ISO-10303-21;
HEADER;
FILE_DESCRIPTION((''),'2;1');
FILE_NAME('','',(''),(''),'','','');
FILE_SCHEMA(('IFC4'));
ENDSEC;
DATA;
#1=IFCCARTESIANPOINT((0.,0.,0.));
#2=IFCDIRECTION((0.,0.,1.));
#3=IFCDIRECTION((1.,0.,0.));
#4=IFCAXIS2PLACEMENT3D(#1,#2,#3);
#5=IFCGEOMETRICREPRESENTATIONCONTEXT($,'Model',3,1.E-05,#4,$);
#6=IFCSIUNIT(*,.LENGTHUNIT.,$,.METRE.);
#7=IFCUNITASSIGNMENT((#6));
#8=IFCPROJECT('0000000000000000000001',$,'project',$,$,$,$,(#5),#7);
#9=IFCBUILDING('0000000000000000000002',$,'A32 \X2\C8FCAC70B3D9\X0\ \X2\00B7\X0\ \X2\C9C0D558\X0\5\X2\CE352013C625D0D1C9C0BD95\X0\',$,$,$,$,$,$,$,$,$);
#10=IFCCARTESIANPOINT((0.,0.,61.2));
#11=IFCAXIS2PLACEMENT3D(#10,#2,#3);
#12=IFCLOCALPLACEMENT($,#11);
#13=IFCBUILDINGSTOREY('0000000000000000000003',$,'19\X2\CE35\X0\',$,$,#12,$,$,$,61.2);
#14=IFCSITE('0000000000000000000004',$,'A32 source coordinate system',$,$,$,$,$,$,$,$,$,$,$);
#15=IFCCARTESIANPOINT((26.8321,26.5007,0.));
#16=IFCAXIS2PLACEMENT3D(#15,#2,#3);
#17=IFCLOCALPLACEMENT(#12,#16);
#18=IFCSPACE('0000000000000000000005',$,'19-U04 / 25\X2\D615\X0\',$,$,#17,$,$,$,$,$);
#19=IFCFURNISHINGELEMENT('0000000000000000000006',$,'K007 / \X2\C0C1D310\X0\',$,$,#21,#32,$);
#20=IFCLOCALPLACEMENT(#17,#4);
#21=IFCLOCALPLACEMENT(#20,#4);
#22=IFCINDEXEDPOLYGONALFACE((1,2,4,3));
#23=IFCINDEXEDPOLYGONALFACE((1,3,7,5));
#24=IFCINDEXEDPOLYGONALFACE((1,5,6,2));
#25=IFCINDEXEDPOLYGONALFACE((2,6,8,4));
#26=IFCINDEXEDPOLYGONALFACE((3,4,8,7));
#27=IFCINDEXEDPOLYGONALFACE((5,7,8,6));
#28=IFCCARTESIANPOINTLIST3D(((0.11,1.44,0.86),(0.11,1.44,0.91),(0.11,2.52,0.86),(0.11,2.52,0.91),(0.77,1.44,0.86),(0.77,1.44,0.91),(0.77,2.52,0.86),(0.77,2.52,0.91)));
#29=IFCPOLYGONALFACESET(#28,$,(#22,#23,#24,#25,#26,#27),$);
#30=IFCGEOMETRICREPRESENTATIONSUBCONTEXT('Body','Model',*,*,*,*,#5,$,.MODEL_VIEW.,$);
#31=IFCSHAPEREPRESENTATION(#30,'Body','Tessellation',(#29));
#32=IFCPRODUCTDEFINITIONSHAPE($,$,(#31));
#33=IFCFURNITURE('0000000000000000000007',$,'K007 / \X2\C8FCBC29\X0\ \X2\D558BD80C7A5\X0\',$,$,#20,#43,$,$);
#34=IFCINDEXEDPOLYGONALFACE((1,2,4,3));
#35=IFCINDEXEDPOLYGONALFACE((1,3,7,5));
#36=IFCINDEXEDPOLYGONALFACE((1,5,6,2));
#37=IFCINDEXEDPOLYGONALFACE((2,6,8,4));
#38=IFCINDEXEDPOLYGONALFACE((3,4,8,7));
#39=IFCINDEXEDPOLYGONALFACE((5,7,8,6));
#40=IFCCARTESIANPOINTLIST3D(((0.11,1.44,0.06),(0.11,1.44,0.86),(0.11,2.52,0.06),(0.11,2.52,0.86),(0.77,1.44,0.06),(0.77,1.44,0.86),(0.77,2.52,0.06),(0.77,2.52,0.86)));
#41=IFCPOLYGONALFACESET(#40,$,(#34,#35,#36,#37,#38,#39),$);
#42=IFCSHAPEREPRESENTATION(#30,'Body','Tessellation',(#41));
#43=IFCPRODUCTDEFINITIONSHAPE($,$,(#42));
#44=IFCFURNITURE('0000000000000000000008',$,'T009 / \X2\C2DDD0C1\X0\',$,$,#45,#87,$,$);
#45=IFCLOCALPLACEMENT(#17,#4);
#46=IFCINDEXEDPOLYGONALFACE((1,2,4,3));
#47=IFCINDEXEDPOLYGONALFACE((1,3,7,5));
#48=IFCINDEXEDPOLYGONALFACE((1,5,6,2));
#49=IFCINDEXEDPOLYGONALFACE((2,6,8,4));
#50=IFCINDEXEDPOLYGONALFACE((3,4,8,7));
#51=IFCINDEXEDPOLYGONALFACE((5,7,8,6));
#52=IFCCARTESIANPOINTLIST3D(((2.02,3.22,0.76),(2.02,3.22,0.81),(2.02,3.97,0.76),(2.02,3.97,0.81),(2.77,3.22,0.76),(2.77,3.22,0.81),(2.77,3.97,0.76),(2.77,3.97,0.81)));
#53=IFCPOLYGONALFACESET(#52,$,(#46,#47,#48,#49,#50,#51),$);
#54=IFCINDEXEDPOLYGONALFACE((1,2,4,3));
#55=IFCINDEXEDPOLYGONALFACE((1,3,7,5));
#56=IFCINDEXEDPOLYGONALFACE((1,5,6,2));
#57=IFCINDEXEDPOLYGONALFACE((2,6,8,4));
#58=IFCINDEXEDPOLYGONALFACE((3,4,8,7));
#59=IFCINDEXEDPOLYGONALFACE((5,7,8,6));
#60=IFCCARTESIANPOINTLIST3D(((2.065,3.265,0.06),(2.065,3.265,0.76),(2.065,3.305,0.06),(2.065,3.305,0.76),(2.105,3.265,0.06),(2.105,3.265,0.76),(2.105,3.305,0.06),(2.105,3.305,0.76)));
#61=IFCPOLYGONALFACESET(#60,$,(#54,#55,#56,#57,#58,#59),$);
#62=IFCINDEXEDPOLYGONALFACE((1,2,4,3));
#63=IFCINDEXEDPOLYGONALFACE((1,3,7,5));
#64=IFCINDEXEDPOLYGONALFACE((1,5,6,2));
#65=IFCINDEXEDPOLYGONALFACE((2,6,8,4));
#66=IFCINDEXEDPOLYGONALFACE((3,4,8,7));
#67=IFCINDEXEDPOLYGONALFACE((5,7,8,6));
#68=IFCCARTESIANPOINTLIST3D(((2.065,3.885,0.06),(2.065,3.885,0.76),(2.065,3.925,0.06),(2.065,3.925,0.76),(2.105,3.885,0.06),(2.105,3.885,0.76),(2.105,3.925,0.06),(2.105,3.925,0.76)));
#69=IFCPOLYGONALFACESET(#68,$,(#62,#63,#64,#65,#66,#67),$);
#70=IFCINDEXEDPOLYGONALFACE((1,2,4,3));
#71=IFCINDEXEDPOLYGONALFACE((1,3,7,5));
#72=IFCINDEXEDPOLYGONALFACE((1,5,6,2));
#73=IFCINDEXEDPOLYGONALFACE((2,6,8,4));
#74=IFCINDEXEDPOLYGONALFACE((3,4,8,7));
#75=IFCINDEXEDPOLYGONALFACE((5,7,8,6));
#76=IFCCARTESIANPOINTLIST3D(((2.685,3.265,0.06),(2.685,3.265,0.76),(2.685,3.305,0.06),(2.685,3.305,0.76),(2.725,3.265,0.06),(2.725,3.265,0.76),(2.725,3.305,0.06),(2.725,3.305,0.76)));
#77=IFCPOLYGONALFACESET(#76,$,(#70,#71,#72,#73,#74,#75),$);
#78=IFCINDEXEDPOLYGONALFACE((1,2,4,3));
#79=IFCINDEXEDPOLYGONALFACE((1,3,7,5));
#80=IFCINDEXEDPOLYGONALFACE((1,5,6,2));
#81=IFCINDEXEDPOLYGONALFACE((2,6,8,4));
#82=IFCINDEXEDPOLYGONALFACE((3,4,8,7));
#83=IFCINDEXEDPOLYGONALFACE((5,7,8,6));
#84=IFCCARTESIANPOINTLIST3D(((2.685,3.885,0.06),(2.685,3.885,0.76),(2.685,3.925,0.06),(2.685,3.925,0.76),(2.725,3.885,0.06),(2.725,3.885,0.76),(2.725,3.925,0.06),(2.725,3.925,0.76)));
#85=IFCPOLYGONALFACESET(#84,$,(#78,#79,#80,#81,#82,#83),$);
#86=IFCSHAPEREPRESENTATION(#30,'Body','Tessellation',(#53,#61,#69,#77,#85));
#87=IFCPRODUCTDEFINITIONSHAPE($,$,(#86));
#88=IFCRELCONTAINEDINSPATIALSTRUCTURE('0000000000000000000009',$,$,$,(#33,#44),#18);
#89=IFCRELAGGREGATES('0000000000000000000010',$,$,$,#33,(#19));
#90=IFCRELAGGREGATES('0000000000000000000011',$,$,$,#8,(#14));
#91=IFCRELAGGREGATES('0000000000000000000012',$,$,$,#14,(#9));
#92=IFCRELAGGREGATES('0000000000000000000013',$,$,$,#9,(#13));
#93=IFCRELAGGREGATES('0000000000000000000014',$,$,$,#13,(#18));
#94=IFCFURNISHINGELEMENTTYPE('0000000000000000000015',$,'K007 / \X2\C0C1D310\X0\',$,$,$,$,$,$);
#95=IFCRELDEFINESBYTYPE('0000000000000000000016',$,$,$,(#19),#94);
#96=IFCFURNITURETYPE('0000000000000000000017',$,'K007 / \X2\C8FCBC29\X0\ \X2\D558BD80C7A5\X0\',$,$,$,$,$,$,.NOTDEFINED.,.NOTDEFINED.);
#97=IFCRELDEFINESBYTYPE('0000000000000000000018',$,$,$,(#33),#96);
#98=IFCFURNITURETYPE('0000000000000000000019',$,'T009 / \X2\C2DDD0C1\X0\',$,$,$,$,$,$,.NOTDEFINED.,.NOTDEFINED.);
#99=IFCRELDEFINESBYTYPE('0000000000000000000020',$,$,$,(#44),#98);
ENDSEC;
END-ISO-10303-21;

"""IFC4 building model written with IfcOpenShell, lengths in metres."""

from ifc_helpers import new_model, si_unit, frame, origin, origin_with_axes, place, context, subcontext, project, spatial, polyline, outline, extrude, source, transform, mapped, type_object, type_shapes, element, aggregate, save


model = new_model("IFC4")

# Units and contexts
model_context = context("Model", 3, precision=1e-05, world=origin_with_axes())
body_context = subcontext(model_context, "Body", "Model", "MODEL_VIEW")
ifc_project = project(units=[si_unit("LENGTHUNIT", "METRE")], contexts=[model_context])

# Site, building, storey
site = spatial("IfcSite", under=ifc_project, Name="A32 source coordinate system")
building = spatial("IfcBuilding", under=site, Name="A32 주거동 · 지하5층–옥탑지붕")
storey_placement = place(None, frame((0.0, 0.0, 61.2), z_axis=(0.0, 0.0, 1.0), x_axis=(1.0, 0.0, 0.0)))
storey = spatial("IfcBuildingStorey", under=building, at=storey_placement, Name="19층", Elevation=61.2)

# Shared definitions
space_1_placement = place(storey_placement, frame((26.8321, 26.5007, 0.0), z_axis=(0.0, 0.0, 1.0), x_axis=(1.0, 0.0, 0.0)))
space_1 = spatial("IfcSpace", under=storey, at=space_1_placement, Name="19-U04 / 25형")

# Furnishing element
furnishing_element_type_1 = type_object("IfcFurnishingElementType", Name="K007 / 상판")
shared_shape_1 = source(origin(), body_context, "Body", "SweptSolid", [
    extrude(outline(polyline([(0.77, 2.52), (0.77, 1.44), (0.11, 1.44), (0.11, 2.52), (0.77, 2.52)])), frame((0.0, 0.0, 0.86)), (0.0, 0.0, 1.0), 0.05),
])
type_shapes(furnishing_element_type_1, [shared_shape_1])
furniture_1_placement = place(space_1_placement, origin_with_axes())
furnishing_1_placement = place(furniture_1_placement, origin_with_axes())
furnishing_1 = element("IfcFurnishingElement", 1, at=furnishing_1_placement, type_object=furnishing_element_type_1, Name="K007 / 상판", context=body_context, shape_type="MappedRepresentation", body=[
    mapped(shared_shape_1, transform((0.0, 0.0, 0.0), scale=1.0)),
])

# Furniture
furniture_type_1 = type_object("IfcFurnitureType", Name="K007 / 주방 하부장", AssemblyPlace="NOTDEFINED", PredefinedType="NOTDEFINED")
shared_shape_2 = source(origin(), body_context, "Body", "SweptSolid", [
    extrude(outline(polyline([(0.11, 2.52), (0.77, 2.52), (0.77, 1.44), (0.11, 1.44), (0.11, 2.52)])), frame((0.0, 0.0, 0.06)), (0.0, 0.0, 1.0), 0.8),
])
type_shapes(furniture_type_1, [shared_shape_2])
furniture_1 = element("IfcFurniture", 2, at=furniture_1_placement, inside=space_1, type_object=furniture_type_1, Name="K007 / 주방 하부장", context=body_context, shape_type="MappedRepresentation", body=[
    mapped(shared_shape_2, transform((0.0, 0.0, 0.0), scale=1.0)),
])
aggregate(furniture_1, [furnishing_1])
furniture_type_2 = type_object("IfcFurnitureType", Name="T009 / 식탁", AssemblyPlace="NOTDEFINED", PredefinedType="NOTDEFINED")
shared_shape_3 = source(origin(), body_context, "Body", "SweptSolid", [
    extrude(outline(polyline([(2.77, 3.22), (2.02, 3.22), (2.02, 3.97), (2.77, 3.97), (2.77, 3.22)])), frame((0.0, 0.0, 0.76)), (0.0, 0.0, 1.0), 0.05),
    extrude(outline(polyline([(2.065, 3.265), (2.065, 3.305), (2.105, 3.305), (2.105, 3.265), (2.065, 3.265)])), frame((0.0, 0.0, 0.06)), (0.0, 0.0, 1.0), 0.7),
    extrude(outline(polyline([(2.065, 3.885), (2.065, 3.925), (2.105, 3.925), (2.105, 3.885), (2.065, 3.885)])), frame((0.0, 0.0, 0.06)), (0.0, 0.0, 1.0), 0.7),
    extrude(outline(polyline([(2.685, 3.265), (2.685, 3.305), (2.725, 3.305), (2.725, 3.265), (2.685, 3.265)])), frame((0.0, 0.0, 0.06)), (0.0, 0.0, 1.0), 0.7),
    extrude(outline(polyline([(2.685, 3.885), (2.685, 3.925), (2.725, 3.925), (2.725, 3.885), (2.685, 3.885)])), frame((0.0, 0.0, 0.06)), (0.0, 0.0, 1.0), 0.7),
])
type_shapes(furniture_type_2, [shared_shape_3])
furniture_2_placement = place(space_1_placement, origin_with_axes())
element("IfcFurniture", 3, at=furniture_2_placement, inside=space_1, type_object=furniture_type_2, Name="T009 / 식탁", context=body_context, shape_type="MappedRepresentation", body=[
    mapped(shared_shape_3, transform((0.0, 0.0, 0.0), scale=1.0)),
])

save(model, "model.ifc")
